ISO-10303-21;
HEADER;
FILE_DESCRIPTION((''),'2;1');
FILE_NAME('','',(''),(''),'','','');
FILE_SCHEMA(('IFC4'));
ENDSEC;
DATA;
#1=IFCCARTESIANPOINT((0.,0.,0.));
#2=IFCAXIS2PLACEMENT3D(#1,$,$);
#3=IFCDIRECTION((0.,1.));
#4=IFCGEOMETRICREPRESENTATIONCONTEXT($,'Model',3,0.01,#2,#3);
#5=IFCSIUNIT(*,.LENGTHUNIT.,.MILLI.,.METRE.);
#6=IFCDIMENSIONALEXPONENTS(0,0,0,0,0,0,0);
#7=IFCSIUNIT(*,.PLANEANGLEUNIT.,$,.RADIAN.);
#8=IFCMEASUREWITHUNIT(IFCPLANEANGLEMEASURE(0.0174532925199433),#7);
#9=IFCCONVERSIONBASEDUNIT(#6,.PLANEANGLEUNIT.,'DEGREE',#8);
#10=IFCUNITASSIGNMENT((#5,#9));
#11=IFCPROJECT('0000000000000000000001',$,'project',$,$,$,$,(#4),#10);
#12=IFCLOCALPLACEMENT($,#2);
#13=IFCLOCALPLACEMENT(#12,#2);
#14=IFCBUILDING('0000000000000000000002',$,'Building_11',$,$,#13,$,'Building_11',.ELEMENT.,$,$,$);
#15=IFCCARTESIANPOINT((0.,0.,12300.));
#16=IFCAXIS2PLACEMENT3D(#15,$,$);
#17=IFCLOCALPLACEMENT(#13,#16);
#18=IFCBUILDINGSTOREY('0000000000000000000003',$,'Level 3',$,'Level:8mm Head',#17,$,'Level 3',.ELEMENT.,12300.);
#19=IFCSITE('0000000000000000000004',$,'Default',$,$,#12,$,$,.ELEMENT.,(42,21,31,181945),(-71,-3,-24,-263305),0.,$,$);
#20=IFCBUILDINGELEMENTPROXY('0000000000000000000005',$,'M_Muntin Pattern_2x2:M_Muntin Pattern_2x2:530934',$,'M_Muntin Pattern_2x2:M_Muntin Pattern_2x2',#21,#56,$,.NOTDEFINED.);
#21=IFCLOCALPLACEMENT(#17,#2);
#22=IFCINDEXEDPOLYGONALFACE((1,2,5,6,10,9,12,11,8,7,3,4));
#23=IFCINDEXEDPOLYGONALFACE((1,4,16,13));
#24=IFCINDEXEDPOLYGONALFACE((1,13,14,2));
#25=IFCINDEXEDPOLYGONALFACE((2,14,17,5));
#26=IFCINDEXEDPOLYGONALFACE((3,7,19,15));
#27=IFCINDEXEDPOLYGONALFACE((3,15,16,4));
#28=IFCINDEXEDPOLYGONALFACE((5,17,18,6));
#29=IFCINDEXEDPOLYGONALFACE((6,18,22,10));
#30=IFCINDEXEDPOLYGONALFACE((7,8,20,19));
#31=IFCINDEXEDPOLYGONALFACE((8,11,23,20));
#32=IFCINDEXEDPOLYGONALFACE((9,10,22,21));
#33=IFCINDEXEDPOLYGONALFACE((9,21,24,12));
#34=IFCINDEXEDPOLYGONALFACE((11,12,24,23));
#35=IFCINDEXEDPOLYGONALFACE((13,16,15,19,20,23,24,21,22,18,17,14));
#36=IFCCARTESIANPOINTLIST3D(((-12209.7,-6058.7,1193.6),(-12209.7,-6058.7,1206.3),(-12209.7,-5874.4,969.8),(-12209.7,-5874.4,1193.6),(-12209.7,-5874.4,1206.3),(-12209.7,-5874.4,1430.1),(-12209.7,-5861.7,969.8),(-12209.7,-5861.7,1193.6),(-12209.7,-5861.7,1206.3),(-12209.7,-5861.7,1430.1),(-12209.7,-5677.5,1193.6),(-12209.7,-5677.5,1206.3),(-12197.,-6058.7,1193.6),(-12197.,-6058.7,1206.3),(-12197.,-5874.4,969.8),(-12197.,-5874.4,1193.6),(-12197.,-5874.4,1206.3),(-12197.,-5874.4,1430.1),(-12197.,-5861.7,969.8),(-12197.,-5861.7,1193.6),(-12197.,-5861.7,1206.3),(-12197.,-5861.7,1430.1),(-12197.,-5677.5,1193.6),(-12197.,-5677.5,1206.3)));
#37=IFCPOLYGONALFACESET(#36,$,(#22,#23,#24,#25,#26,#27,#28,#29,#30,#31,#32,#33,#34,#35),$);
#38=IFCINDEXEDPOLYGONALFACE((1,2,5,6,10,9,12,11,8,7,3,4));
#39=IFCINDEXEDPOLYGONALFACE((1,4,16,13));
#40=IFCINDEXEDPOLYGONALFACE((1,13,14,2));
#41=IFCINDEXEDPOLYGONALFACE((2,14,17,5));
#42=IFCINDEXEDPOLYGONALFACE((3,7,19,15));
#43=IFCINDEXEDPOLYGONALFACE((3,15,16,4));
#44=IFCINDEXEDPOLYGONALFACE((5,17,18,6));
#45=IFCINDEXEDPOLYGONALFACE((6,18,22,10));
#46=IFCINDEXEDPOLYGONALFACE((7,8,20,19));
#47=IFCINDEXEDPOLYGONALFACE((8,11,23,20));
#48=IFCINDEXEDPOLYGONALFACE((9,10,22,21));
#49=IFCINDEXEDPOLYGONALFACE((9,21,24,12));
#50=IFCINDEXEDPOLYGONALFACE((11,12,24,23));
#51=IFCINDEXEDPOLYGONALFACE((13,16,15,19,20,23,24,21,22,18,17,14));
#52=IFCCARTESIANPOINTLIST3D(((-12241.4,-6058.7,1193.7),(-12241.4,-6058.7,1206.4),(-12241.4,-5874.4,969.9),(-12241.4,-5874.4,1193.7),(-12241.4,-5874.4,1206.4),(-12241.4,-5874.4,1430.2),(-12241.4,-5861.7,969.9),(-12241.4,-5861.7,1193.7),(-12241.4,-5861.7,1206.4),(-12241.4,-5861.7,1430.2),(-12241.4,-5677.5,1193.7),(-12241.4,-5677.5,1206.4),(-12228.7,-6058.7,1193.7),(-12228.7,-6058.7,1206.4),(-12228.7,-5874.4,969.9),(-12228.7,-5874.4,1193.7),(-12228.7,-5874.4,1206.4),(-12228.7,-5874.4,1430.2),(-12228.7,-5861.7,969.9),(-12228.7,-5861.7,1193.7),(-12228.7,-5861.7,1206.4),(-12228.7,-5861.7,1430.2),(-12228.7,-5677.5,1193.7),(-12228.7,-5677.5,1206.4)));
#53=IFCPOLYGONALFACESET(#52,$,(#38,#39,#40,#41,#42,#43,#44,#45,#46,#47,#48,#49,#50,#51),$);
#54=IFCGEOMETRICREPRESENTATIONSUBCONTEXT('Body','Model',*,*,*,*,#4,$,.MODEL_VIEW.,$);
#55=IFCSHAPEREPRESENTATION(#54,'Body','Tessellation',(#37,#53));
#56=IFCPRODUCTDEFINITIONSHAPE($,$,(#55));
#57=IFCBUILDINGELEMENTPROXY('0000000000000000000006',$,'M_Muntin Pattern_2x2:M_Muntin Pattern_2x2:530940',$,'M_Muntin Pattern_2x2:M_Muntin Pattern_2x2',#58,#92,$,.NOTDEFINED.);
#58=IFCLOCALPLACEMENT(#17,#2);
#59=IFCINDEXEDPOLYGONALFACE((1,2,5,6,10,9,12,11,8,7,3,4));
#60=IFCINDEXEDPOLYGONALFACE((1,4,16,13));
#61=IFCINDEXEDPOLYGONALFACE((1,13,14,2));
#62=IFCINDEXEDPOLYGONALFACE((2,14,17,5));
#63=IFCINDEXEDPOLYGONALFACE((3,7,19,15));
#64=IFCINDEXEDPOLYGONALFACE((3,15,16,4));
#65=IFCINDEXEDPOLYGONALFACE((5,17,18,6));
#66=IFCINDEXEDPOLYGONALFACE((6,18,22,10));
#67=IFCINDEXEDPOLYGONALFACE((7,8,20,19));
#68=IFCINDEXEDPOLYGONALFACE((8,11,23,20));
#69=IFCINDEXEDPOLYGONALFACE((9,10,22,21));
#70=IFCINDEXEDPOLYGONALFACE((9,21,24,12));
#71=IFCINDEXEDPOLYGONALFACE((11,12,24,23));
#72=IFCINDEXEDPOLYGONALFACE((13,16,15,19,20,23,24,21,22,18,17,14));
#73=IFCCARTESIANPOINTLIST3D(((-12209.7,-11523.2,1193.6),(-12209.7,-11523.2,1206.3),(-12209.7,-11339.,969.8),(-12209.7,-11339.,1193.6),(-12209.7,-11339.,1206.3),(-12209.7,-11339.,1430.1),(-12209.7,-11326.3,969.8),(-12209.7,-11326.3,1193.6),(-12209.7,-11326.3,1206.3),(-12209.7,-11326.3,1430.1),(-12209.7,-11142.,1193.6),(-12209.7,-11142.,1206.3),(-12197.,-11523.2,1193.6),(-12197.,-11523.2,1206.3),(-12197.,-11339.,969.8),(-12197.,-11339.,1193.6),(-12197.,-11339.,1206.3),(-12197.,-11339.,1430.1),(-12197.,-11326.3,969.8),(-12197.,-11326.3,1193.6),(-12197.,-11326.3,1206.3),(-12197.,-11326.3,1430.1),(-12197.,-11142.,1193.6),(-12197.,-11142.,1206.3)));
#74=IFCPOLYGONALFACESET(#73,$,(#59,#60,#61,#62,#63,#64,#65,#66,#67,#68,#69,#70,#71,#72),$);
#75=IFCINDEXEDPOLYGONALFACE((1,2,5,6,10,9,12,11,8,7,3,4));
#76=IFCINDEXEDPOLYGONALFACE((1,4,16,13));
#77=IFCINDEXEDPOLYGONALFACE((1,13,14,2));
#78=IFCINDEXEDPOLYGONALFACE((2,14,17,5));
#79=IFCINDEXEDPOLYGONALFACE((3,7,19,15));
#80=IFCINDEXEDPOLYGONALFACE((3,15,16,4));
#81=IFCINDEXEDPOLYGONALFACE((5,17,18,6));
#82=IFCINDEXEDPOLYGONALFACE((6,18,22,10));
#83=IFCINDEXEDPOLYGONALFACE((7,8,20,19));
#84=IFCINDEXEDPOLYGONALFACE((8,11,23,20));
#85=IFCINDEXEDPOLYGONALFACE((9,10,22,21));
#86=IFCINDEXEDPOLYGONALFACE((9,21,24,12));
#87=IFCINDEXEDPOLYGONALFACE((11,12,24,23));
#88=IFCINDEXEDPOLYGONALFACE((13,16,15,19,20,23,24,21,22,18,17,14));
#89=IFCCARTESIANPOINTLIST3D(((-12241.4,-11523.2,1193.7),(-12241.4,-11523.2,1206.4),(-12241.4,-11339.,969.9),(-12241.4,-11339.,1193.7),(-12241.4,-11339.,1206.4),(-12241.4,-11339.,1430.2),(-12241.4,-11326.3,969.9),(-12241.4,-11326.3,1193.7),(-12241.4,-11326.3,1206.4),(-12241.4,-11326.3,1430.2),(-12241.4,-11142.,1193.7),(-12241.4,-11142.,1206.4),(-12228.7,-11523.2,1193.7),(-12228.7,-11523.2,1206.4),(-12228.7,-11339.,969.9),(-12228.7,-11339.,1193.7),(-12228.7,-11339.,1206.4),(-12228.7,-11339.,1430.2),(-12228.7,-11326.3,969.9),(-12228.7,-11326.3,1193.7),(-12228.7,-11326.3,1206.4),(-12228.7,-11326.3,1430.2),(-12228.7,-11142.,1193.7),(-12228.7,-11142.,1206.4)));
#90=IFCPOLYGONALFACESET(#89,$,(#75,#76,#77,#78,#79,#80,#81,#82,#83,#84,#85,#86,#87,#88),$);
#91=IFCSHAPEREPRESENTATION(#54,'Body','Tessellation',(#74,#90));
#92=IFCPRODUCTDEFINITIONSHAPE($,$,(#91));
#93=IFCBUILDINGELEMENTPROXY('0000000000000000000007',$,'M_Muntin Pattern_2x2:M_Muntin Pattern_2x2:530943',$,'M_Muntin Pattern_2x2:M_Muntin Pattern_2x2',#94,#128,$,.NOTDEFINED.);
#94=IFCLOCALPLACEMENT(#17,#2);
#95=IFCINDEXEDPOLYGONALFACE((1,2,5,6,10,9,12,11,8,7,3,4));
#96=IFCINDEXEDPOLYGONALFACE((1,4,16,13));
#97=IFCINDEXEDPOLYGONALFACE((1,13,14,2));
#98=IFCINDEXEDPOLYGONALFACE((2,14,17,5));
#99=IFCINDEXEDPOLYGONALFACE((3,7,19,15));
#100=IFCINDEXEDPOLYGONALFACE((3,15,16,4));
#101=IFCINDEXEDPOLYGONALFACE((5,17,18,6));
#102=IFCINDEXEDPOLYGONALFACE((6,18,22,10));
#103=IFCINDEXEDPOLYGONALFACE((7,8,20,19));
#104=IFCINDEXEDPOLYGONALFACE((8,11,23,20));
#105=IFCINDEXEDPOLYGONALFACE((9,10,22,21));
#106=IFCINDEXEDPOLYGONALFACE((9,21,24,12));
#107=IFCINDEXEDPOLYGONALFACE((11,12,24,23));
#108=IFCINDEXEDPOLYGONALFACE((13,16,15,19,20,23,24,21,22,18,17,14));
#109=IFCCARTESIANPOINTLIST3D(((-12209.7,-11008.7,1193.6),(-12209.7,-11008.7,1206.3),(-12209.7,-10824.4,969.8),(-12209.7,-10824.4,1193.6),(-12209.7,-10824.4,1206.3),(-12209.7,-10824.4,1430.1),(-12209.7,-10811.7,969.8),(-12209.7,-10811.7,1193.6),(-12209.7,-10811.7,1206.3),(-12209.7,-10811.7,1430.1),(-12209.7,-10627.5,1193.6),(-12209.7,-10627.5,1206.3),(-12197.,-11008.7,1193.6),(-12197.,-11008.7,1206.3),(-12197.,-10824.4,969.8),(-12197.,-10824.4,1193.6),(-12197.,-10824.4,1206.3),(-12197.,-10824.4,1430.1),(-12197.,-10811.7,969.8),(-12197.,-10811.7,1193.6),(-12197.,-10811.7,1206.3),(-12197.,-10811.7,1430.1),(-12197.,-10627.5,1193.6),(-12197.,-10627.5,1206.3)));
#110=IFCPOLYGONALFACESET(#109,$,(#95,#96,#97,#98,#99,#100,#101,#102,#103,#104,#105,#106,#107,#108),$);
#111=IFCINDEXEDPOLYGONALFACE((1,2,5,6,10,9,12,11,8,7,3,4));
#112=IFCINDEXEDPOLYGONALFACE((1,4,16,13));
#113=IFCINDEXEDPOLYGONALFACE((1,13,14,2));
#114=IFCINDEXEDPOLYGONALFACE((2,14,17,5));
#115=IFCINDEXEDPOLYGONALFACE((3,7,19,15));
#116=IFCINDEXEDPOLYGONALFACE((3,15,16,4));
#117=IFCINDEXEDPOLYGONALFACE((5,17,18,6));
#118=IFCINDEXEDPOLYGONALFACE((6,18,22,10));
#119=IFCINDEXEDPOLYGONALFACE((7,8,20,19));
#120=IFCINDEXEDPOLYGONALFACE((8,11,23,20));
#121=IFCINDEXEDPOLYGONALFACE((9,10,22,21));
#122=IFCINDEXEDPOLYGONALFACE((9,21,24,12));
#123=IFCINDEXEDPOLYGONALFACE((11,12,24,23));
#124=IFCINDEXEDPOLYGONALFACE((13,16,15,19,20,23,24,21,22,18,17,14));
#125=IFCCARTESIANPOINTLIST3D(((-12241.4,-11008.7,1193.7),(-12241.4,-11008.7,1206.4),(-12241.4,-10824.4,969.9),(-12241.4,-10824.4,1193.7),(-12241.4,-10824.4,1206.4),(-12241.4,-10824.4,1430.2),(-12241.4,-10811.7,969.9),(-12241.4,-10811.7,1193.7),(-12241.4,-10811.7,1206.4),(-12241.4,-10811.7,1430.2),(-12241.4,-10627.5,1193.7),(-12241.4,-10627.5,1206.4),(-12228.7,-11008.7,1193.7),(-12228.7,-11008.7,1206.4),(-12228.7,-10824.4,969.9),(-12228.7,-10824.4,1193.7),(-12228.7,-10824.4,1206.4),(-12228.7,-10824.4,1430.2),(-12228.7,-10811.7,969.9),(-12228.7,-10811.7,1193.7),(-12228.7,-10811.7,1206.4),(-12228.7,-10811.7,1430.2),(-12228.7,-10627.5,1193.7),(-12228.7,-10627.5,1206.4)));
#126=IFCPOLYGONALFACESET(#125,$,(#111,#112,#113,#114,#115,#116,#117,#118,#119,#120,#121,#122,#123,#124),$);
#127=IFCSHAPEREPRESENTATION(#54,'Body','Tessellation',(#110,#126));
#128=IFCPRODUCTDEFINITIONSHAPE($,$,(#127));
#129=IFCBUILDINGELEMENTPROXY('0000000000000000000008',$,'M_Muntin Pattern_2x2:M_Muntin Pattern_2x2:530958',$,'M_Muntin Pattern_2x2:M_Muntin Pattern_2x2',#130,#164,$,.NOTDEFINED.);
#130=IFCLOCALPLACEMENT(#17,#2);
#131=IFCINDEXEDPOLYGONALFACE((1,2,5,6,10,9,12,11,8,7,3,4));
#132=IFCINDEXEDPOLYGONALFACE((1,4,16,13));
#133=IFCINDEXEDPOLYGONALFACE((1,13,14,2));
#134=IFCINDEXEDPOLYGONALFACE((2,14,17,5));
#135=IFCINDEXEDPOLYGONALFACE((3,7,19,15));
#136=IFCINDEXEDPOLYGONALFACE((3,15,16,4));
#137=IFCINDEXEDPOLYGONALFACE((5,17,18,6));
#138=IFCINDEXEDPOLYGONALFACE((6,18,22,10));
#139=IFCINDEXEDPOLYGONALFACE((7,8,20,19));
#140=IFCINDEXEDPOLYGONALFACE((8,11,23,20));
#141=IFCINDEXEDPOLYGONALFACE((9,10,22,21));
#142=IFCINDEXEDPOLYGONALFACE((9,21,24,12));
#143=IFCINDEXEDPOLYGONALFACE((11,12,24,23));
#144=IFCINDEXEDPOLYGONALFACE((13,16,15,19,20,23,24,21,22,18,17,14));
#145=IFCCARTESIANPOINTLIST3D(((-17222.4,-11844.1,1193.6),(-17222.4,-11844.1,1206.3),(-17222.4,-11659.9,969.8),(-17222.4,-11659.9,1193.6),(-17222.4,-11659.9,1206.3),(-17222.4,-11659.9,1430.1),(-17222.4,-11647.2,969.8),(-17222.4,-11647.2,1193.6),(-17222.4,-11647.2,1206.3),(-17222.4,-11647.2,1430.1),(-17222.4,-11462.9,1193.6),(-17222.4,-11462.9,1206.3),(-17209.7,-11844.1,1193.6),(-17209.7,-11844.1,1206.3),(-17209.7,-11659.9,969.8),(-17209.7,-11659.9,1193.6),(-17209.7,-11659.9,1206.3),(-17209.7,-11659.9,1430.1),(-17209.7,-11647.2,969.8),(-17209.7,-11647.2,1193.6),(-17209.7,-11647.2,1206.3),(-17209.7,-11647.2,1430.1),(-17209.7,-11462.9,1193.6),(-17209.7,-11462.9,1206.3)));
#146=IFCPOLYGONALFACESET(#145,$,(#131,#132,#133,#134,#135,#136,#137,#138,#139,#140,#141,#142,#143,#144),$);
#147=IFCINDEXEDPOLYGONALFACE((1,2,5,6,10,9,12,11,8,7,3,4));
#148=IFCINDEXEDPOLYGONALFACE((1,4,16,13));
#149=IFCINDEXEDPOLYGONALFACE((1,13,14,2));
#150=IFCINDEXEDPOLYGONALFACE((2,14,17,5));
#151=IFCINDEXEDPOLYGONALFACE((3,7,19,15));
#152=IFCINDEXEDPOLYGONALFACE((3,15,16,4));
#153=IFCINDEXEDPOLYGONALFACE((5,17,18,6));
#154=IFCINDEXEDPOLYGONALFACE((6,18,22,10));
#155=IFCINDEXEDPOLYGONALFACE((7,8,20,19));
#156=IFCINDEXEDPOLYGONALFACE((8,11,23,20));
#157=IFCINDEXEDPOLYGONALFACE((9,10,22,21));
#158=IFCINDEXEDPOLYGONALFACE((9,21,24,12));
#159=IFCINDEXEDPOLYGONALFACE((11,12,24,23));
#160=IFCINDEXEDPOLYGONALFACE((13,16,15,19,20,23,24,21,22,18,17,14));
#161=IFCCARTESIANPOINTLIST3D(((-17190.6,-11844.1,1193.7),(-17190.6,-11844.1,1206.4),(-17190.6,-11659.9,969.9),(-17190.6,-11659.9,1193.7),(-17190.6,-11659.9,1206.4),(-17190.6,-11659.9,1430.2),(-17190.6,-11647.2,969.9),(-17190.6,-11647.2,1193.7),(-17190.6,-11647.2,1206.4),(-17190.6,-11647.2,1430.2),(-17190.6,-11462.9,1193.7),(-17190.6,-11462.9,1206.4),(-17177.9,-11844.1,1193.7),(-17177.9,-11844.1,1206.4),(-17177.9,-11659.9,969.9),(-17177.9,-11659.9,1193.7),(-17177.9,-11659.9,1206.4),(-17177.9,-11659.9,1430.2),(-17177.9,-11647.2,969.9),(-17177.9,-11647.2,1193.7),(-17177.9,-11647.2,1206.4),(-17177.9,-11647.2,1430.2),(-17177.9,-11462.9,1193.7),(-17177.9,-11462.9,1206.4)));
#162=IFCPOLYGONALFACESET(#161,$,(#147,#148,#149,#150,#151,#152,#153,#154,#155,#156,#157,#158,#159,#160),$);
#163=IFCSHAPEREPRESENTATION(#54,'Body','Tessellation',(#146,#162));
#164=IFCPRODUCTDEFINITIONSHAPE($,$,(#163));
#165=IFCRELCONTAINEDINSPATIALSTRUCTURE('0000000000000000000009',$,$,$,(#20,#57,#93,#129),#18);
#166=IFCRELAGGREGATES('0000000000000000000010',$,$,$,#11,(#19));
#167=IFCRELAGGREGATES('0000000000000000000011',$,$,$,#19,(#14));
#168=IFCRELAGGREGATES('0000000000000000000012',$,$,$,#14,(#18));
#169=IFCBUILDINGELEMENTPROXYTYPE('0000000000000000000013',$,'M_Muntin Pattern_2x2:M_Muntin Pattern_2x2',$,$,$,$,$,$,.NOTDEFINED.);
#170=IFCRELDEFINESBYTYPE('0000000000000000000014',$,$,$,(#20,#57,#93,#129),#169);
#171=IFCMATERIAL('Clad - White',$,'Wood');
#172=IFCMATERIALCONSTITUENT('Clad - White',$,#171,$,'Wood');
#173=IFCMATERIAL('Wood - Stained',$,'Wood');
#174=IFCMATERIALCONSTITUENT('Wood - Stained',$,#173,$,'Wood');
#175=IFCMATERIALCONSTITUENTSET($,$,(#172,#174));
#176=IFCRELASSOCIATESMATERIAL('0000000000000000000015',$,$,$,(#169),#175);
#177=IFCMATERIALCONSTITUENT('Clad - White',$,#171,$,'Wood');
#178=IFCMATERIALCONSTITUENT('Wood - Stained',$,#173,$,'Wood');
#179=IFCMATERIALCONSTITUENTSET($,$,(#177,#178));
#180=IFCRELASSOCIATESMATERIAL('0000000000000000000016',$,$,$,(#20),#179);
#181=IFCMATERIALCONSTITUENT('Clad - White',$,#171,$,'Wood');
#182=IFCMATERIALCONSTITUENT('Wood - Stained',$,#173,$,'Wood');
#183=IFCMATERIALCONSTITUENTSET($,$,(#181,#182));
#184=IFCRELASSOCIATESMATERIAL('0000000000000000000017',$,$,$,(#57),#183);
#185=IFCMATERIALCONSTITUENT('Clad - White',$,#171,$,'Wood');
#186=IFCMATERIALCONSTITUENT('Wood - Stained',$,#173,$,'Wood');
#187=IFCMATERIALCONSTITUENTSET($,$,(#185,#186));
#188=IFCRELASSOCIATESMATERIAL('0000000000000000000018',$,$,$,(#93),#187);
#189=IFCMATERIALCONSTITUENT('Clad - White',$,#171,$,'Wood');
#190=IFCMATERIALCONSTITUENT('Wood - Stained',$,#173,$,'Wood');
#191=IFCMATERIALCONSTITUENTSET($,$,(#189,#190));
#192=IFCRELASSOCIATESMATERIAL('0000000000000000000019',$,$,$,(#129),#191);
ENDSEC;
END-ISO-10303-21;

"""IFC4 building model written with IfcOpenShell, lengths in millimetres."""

from ifc_helpers import new_model, entity, si_unit, converted_unit, direction, frame, origin, place, context, subcontext, project, spatial, indexed_curve, outline, extrude, source, transform, mapped, material, constituent, constituent_set, type_object, type_shapes, element, save


model = new_model("IFC4")

# Units and contexts
model_context = context("Model", 3, precision=0.01, world=origin(), true_north=direction((0.0, 1.0)))
body_context = subcontext(model_context, "Body", "Model", "MODEL_VIEW")
ifc_project = project(units=[si_unit("LENGTHUNIT", "METRE", prefix="MILLI"), converted_unit("PLANEANGLEUNIT", "DEGREE", entity("IfcPlaneAngleMeasure", 0.0174532925199433), si_unit("PLANEANGLEUNIT", "RADIAN"), dimensions=[0, 0, 0, 0, 0, 0, 0])], contexts=[model_context])

# Site, building, storey
site_placement = place(None, origin())
site = spatial("IfcSite", under=ifc_project, at=site_placement, Name="Default", CompositionType="ELEMENT", RefLatitude=(42, 21, 31, 181945), RefLongitude=(-71, -3, -24, -263305), RefElevation=0.0)
building_placement = place(site_placement, origin())
building = spatial("IfcBuilding", under=site, at=building_placement, Name="Building_11", LongName="Building_11", CompositionType="ELEMENT")
storey_placement = place(building_placement, frame((0.0, 0.0, 12300.0)))
storey = spatial("IfcBuildingStorey", under=building, at=storey_placement, Name="Level 3", ObjectType="Level:8mm Head", LongName="Level 3", CompositionType="ELEMENT", Elevation=12300.0)

# Building element proxies
ifc_material_1 = material(Name="Clad - White", Category="Wood")
ifc_material_2 = material(Name="Wood - Stained", Category="Wood")
ifc_constituent_1 = constituent(ifc_material_1, Name="Clad - White", Category="Wood")
ifc_constituent_2 = constituent(ifc_material_2, Name="Wood - Stained", Category="Wood")
ifc_constituent_set_1 = constituent_set(constituents=[ifc_constituent_1, ifc_constituent_2])
building_element_proxy_type_1 = type_object("IfcBuildingElementProxyType", Name="M_Muntin Pattern_2x2:M_Muntin Pattern_2x2", PredefinedType="NOTDEFINED", material=ifc_constituent_set_1)
shared_shape_1 = source(origin(), body_context, "Body", "SweptSolid", [
    extrude(outline(indexed_curve([(6.4, -6.4), (230.1, -6.4), (230.1, 6.3), (6.4, 6.3), (6.4, 190.6), (-6.3, 190.6), (-6.3, 6.3), (-230.2, 6.3), (-230.2, -6.4), (-6.3, -6.4), (-6.3, -190.6), (6.4, -190.6), (6.4, -6.4)], self_intersect=False)), frame((0.0, -22.2, 230.1), z_axis=(0.0, 1.0, 0.0), x_axis=(0.0, 0.0, 1.0)), (0.0, 0.0, 1.0), 12.7),
    extrude(outline(indexed_curve([(6.4, -6.4), (230.2, -6.4), (230.2, 6.3), (6.4, 6.3), (6.4, 190.6), (-6.3, 190.6), (-6.3, 6.3), (-230.2, 6.3), (-230.2, -6.4), (-6.3, -6.4), (-6.3, -190.6), (6.4, -190.6), (6.4, -6.4)], self_intersect=False)), frame((0.0, 9.5, 230.2), z_axis=(0.0, 1.0, 0.0), x_axis=(0.0, 0.0, 1.0)), (0.0, 0.0, 1.0), 12.7),
])
type_shapes(building_element_proxy_type_1, [shared_shape_1])
ifc_constituent_3 = constituent(ifc_material_1, Name="Clad - White", Category="Wood")
ifc_constituent_4 = constituent(ifc_material_2, Name="Wood - Stained", Category="Wood")
ifc_constituent_set_2 = constituent_set(constituents=[ifc_constituent_3, ifc_constituent_4])
proxy_1_placement = place(storey_placement, frame((-12219.2, -5868.1, 969.9), z_axis=(0.0, 0.0, 1.0), x_axis=(0.0, 1.0, 0.0)))
element("IfcBuildingElementProxy", 1, at=proxy_1_placement, inside=storey, type_object=building_element_proxy_type_1, material=ifc_constituent_set_2, Name="M_Muntin Pattern_2x2:M_Muntin Pattern_2x2:530934", ObjectType="M_Muntin Pattern_2x2:M_Muntin Pattern_2x2", PredefinedType="NOTDEFINED", context=body_context, shape_type="MappedRepresentation", body=[
    mapped(shared_shape_1, transform((0.0, 0.0, 0.0), scale=1.0)),
])
ifc_constituent_5 = constituent(ifc_material_1, Name="Clad - White", Category="Wood")
ifc_constituent_6 = constituent(ifc_material_2, Name="Wood - Stained", Category="Wood")
ifc_constituent_set_3 = constituent_set(constituents=[ifc_constituent_5, ifc_constituent_6])
proxy_2_placement = place(storey_placement, frame((-12219.2, -11332.6, 969.9), z_axis=(0.0, 0.0, 1.0), x_axis=(0.0, 1.0, 0.0)))
element("IfcBuildingElementProxy", 2, at=proxy_2_placement, inside=storey, type_object=building_element_proxy_type_1, material=ifc_constituent_set_3, Name="M_Muntin Pattern_2x2:M_Muntin Pattern_2x2:530940", ObjectType="M_Muntin Pattern_2x2:M_Muntin Pattern_2x2", PredefinedType="NOTDEFINED", context=body_context, shape_type="MappedRepresentation", body=[
    mapped(shared_shape_1, transform((0.0, 0.0, 0.0), scale=1.0)),
])
ifc_constituent_7 = constituent(ifc_material_1, Name="Clad - White", Category="Wood")
ifc_constituent_8 = constituent(ifc_material_2, Name="Wood - Stained", Category="Wood")
ifc_constituent_set_4 = constituent_set(constituents=[ifc_constituent_7, ifc_constituent_8])
proxy_3_placement = place(storey_placement, frame((-12219.2, -10818.1, 969.9), z_axis=(0.0, 0.0, 1.0), x_axis=(0.0, 1.0, 0.0)))
element("IfcBuildingElementProxy", 3, at=proxy_3_placement, inside=storey, type_object=building_element_proxy_type_1, material=ifc_constituent_set_4, Name="M_Muntin Pattern_2x2:M_Muntin Pattern_2x2:530943", ObjectType="M_Muntin Pattern_2x2:M_Muntin Pattern_2x2", PredefinedType="NOTDEFINED", context=body_context, shape_type="MappedRepresentation", body=[
    mapped(shared_shape_1, transform((0.0, 0.0, 0.0), scale=1.0)),
])
ifc_constituent_9 = constituent(ifc_material_1, Name="Clad - White", Category="Wood")
ifc_constituent_10 = constituent(ifc_material_2, Name="Wood - Stained", Category="Wood")
ifc_constituent_set_5 = constituent_set(constituents=[ifc_constituent_9, ifc_constituent_10])
proxy_4_placement = place(storey_placement, frame((-17200.2, -11653.5, 969.9), z_axis=(0.0, 0.0, 1.0), x_axis=(0.0, -1.0, 0.0)))
element("IfcBuildingElementProxy", 4, at=proxy_4_placement, inside=storey, type_object=building_element_proxy_type_1, material=ifc_constituent_set_5, Name="M_Muntin Pattern_2x2:M_Muntin Pattern_2x2:530958", ObjectType="M_Muntin Pattern_2x2:M_Muntin Pattern_2x2", PredefinedType="NOTDEFINED", context=body_context, shape_type="MappedRepresentation", body=[
    mapped(shared_shape_1, transform((0.0, 0.0, 0.0), scale=1.0)),
])

save(model, "model.ifc")
